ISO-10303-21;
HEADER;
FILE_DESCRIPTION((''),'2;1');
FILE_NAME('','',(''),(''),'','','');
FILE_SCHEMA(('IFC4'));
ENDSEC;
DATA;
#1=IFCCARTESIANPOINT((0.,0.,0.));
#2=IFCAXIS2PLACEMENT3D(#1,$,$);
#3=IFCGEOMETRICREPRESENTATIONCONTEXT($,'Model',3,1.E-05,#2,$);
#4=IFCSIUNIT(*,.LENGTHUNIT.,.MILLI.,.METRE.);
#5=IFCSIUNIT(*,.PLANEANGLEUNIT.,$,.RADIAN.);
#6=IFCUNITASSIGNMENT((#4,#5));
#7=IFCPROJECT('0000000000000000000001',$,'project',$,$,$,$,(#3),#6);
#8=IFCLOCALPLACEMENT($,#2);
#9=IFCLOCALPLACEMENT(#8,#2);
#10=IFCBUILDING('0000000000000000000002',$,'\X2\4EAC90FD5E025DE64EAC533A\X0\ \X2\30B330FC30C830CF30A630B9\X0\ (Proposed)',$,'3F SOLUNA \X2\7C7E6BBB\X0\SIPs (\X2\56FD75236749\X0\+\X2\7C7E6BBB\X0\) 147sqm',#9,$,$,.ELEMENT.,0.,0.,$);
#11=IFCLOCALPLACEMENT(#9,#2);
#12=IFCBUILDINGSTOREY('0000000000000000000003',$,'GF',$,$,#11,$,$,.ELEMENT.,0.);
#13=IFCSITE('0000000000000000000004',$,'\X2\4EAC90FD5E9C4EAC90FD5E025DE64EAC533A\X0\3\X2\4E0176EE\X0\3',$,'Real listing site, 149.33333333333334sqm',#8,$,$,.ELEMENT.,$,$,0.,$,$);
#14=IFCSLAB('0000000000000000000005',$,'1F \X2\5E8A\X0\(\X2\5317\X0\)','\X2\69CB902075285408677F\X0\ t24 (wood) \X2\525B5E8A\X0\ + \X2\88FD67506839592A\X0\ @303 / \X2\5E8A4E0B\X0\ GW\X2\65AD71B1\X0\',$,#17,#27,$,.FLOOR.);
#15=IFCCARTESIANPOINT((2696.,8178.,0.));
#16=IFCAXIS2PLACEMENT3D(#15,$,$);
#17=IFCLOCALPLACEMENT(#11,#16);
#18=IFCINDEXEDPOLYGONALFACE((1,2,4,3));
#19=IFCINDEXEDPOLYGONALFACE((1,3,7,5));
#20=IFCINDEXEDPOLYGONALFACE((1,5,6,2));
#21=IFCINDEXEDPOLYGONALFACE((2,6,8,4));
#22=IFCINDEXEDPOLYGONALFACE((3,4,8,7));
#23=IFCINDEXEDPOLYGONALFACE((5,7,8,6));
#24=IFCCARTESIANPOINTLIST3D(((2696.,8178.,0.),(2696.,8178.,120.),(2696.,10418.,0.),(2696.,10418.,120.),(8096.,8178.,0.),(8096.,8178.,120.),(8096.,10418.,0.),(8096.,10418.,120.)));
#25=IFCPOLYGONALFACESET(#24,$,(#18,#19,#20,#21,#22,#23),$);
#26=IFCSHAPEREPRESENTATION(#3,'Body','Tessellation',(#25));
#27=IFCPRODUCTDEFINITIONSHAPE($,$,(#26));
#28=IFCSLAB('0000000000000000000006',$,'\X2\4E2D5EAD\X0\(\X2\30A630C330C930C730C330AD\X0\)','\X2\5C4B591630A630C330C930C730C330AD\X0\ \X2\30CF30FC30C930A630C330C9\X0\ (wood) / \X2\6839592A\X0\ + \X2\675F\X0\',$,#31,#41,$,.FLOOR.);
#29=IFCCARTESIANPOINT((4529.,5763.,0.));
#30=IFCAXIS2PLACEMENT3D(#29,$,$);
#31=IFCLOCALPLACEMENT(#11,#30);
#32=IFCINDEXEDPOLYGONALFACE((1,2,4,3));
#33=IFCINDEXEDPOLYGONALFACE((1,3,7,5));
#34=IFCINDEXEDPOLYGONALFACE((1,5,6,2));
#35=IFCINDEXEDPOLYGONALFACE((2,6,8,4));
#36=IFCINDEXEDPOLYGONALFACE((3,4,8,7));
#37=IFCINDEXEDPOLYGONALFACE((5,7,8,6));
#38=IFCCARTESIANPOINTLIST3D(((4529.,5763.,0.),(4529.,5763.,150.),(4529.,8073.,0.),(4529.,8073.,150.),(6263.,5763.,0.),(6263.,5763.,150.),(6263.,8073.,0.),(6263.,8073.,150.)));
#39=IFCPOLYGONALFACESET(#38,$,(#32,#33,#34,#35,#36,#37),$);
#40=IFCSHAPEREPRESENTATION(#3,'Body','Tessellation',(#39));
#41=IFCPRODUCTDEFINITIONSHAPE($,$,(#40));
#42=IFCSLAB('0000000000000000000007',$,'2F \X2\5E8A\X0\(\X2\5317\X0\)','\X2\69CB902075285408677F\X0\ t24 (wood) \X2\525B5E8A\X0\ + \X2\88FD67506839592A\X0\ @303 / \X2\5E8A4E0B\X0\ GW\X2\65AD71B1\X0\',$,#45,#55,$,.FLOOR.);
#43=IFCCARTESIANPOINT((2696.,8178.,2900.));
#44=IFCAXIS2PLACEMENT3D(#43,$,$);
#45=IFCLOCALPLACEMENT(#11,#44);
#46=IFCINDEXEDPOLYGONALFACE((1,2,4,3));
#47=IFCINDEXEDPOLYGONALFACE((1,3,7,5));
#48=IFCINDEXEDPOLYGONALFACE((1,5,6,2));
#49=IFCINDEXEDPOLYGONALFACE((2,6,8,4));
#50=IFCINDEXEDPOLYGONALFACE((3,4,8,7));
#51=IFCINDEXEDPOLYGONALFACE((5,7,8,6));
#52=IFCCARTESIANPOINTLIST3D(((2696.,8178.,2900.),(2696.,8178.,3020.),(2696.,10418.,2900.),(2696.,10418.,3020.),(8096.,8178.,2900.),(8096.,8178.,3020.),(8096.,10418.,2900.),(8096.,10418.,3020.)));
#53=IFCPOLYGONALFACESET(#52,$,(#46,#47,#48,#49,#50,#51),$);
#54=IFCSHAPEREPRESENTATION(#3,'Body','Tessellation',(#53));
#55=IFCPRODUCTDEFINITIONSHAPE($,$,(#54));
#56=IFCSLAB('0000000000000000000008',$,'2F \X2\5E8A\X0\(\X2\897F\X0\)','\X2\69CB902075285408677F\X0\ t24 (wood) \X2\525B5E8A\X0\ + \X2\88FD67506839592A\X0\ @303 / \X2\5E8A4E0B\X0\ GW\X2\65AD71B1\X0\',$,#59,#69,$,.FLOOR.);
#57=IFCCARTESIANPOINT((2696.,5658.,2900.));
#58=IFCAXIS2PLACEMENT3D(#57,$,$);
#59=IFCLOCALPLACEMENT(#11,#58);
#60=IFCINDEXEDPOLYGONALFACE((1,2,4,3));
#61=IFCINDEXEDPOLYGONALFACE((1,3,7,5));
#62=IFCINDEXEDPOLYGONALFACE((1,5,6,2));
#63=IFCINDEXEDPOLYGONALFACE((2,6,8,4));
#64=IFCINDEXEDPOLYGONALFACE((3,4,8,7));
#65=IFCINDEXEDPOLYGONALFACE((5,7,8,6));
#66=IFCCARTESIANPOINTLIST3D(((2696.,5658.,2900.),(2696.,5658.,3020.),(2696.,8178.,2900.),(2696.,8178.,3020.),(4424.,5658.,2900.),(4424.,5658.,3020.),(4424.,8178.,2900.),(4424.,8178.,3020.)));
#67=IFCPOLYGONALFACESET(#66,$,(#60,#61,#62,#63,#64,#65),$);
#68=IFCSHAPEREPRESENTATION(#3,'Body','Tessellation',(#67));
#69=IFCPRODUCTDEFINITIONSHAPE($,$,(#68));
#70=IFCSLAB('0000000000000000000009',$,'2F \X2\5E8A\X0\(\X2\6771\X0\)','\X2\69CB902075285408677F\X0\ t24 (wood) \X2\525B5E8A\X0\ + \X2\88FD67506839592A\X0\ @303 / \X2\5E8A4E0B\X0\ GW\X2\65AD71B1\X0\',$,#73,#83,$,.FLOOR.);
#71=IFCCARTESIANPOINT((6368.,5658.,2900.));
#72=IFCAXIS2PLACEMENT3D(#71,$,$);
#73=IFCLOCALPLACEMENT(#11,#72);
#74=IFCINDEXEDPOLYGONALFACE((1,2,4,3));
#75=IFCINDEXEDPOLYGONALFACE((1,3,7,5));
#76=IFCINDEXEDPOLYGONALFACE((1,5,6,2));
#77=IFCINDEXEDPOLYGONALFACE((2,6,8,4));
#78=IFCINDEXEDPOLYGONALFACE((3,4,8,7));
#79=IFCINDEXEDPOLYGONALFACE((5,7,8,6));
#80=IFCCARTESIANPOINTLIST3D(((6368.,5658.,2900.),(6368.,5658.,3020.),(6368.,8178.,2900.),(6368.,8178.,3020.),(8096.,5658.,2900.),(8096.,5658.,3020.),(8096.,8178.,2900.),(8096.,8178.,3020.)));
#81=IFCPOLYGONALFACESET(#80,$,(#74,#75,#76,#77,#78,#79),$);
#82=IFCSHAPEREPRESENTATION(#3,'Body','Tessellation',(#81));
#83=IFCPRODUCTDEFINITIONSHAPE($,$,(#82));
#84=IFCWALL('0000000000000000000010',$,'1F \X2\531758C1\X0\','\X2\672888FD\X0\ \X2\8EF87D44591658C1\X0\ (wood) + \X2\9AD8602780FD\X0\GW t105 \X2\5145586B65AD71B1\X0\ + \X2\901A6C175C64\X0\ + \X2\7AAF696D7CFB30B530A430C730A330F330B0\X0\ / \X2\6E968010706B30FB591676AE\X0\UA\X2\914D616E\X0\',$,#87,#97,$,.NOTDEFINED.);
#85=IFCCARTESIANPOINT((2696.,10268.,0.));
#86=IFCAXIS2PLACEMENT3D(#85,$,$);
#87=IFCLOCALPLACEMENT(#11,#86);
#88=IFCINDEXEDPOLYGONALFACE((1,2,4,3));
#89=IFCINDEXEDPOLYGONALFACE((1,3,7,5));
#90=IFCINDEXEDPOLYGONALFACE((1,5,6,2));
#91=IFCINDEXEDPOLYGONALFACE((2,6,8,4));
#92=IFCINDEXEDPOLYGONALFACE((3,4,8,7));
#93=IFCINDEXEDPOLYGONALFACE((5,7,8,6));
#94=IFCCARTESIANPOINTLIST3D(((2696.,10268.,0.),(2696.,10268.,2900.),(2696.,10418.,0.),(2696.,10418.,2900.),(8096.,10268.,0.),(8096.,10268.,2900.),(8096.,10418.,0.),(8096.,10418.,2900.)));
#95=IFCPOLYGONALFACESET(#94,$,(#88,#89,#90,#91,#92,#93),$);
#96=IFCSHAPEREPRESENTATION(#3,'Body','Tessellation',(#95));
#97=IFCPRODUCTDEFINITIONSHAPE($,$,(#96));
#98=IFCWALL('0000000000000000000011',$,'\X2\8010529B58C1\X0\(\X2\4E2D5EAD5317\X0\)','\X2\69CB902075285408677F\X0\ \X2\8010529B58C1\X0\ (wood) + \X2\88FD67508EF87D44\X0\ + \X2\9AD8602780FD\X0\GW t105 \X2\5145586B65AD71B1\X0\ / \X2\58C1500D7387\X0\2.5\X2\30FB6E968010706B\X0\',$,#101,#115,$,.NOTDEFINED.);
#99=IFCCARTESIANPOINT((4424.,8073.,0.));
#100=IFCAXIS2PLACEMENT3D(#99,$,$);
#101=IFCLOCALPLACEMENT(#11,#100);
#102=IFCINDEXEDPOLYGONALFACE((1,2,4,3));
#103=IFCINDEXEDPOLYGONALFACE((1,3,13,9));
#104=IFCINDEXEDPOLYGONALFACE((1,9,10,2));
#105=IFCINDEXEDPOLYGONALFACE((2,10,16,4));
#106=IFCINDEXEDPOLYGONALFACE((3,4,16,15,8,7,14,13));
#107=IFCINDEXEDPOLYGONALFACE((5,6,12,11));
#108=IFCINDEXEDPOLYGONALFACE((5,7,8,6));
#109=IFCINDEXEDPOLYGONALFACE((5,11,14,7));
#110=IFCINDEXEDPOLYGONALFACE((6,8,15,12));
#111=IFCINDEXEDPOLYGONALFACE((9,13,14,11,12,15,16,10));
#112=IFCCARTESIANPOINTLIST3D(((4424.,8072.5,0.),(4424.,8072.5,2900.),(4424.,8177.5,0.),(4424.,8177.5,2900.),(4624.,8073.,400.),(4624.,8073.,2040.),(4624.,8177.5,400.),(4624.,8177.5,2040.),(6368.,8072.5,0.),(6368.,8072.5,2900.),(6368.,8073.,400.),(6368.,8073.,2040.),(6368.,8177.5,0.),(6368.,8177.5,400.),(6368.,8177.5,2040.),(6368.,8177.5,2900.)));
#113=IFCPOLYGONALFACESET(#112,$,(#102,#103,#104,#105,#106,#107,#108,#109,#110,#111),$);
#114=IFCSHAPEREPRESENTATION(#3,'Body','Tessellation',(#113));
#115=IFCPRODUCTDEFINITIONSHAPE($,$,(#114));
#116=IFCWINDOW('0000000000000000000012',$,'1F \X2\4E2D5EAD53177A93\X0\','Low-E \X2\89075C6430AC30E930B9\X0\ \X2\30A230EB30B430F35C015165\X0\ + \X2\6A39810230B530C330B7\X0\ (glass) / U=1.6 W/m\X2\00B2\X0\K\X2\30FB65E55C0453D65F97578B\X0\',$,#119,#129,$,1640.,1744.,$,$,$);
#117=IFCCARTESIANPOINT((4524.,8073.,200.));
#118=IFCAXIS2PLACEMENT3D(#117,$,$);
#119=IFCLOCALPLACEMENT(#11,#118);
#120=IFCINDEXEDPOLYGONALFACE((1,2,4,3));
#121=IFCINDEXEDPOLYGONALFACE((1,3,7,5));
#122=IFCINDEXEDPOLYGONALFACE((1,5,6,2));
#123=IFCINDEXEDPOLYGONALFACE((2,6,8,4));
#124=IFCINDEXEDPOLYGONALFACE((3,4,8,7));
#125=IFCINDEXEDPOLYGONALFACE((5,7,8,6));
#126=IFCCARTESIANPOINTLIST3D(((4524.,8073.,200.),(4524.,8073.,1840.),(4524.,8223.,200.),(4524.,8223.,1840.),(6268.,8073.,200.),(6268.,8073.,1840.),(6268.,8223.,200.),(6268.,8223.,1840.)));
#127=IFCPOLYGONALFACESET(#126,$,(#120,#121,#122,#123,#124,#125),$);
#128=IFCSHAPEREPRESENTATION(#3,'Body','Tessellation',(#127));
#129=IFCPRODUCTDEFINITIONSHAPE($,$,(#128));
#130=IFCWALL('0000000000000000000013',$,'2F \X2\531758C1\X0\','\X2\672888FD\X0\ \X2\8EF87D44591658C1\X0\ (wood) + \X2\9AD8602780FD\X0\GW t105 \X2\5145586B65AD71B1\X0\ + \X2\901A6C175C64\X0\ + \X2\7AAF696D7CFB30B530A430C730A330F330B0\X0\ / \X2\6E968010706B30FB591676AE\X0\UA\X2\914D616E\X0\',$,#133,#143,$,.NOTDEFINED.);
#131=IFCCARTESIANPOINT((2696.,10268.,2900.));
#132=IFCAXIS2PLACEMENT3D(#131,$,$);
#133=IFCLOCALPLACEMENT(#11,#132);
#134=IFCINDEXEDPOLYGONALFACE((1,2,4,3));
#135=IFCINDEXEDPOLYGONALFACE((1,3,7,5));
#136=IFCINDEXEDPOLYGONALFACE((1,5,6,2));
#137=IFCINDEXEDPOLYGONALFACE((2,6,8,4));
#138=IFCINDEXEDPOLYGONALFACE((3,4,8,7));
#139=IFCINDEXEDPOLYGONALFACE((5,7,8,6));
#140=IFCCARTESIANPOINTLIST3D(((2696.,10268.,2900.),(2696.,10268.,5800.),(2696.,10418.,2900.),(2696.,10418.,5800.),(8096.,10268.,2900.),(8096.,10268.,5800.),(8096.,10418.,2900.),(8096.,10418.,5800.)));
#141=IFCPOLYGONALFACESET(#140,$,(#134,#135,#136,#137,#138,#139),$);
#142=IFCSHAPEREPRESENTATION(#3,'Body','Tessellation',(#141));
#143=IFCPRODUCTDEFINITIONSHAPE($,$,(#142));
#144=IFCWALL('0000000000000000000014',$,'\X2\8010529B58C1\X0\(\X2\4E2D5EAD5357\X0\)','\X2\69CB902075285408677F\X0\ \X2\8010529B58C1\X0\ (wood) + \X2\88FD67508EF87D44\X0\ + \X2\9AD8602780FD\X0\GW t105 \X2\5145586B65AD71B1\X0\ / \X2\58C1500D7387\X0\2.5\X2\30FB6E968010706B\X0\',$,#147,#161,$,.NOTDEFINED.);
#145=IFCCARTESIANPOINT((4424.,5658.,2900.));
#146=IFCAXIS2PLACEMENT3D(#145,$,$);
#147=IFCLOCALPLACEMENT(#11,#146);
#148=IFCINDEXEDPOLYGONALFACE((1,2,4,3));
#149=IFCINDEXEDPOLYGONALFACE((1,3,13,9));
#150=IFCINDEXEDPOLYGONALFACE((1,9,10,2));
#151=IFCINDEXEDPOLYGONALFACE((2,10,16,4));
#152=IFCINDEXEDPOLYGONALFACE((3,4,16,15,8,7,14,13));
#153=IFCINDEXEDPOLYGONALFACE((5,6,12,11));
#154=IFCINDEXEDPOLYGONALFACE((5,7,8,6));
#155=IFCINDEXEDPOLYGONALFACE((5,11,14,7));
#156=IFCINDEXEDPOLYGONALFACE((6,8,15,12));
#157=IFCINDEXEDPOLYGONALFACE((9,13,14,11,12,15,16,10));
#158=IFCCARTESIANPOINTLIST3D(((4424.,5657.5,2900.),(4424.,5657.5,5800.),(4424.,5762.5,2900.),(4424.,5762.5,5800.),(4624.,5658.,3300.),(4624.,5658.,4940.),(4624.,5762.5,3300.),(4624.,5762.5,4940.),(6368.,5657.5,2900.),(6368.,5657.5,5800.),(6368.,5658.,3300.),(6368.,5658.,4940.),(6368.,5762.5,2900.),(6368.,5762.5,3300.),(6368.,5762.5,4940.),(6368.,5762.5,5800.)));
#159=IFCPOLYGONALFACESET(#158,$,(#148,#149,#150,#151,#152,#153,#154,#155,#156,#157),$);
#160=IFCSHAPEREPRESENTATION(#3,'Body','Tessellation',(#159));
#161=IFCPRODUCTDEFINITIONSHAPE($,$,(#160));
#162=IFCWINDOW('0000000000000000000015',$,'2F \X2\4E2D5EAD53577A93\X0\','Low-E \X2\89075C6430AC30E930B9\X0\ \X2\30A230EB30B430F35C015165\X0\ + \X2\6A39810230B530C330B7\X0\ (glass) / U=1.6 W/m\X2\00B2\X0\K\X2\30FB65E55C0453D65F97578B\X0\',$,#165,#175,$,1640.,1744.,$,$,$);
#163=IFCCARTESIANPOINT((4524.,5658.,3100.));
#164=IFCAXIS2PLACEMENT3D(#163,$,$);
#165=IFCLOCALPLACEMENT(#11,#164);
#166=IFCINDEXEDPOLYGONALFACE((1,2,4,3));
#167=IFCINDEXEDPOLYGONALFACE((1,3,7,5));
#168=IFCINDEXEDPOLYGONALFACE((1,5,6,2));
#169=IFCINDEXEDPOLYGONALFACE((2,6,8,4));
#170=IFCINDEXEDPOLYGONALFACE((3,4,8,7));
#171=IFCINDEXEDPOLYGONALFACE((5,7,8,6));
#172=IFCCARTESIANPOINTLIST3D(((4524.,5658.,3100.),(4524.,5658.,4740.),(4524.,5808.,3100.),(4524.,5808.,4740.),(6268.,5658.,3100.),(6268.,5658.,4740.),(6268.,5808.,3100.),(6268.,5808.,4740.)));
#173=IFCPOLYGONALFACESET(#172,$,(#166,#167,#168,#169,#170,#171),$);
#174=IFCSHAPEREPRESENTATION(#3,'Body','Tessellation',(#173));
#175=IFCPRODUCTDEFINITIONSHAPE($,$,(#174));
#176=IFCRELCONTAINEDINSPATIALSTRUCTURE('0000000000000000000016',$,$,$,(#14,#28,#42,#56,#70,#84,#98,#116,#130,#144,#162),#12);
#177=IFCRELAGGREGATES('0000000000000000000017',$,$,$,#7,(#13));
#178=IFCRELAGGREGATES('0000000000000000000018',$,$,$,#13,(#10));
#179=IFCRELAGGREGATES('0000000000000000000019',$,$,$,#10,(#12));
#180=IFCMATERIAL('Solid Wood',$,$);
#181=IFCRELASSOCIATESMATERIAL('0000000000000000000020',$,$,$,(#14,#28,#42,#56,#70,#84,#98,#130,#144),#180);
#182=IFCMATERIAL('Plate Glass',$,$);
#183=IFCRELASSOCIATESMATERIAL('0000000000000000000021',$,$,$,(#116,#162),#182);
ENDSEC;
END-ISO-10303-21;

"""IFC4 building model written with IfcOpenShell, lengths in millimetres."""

from ifc_helpers import new_model, si_unit, frame, frame_2d, origin, place, context, project, spatial, rectangle, extrude, material, element, fill, save


model = new_model("IFC4")

# Units and contexts
model_context = context("Model", 3, precision=1e-05, world=origin())
ifc_project = project(units=[si_unit("LENGTHUNIT", "METRE", prefix="MILLI"), si_unit("PLANEANGLEUNIT", "RADIAN")], contexts=[model_context])

# Site, building, storey
site_placement = place(None, origin())
site = spatial("IfcSite", under=ifc_project, at=site_placement, Name="京都府京都市左京区3丁目3", ObjectType="Real listing site, 149.33333333333334sqm", CompositionType="ELEMENT", RefElevation=0.0)
building_placement = place(site_placement, origin())
building = spatial("IfcBuilding", under=site, at=building_placement, Name="京都市左京区 コートハウス (Proposed)", ObjectType="3F SOLUNA 籾殻SIPs (国産杉+籾殻) 147sqm", CompositionType="ELEMENT", ElevationOfRefHeight=0.0, ElevationOfTerrain=0.0)
storey_placement = place(building_placement, origin())
storey = spatial("IfcBuildingStorey", under=building, at=storey_placement, Name="GF", CompositionType="ELEMENT", Elevation=0.0)

# Slabs
ifc_material_1 = material(Name="Solid Wood")
slab_1_placement = place(storey_placement, frame((2696.0, 8178.0, 0.0)))
element("IfcSlab", 1, at=slab_1_placement, inside=storey, material=ifc_material_1, Name="1F 床(北)", Description="構造用合板 t24 (wood) 剛床 + 製材根太 @303 / 床下 GW断熱", PredefinedType="FLOOR", context=model_context, shape_type="SweptSolid", body=[
    extrude(rectangle(XDim=5400.0, YDim=2240.0, at=frame_2d((2700.0, 1120.0))), frame((2696.0, 8178.0, 0.0)), (0.0, 0.0, 1.0), 120.0),
])
slab_2_placement = place(storey_placement, frame((4529.0, 5763.0, 0.0)))
element("IfcSlab", 2, at=slab_2_placement, inside=storey, material=ifc_material_1, Name="中庭(ウッドデッキ)", Description="屋外ウッドデッキ ハードウッド (wood) / 根太 + 束", PredefinedType="FLOOR", context=model_context, shape_type="SweptSolid", body=[
    extrude(rectangle(XDim=1734.0, YDim=2310.0, at=frame_2d((867.0, 1155.0))), frame((4529.0, 5763.0, 0.0)), (0.0, 0.0, 1.0), 150.0),
])
slab_3_placement = place(storey_placement, frame((2696.0, 8178.0, 2900.0)))
element("IfcSlab", 3, at=slab_3_placement, inside=storey, material=ifc_material_1, Name="2F 床(北)", Description="構造用合板 t24 (wood) 剛床 + 製材根太 @303 / 床下 GW断熱", PredefinedType="FLOOR", context=model_context, shape_type="SweptSolid", body=[
    extrude(rectangle(XDim=5400.0, YDim=2240.0, at=frame_2d((2700.0, 1120.0))), frame((2696.0, 8178.0, 2900.0)), (0.0, 0.0, 1.0), 120.0),
])
slab_4_placement = place(storey_placement, frame((2696.0, 5658.0, 2900.0)))
element("IfcSlab", 4, at=slab_4_placement, inside=storey, material=ifc_material_1, Name="2F 床(西)", Description="構造用合板 t24 (wood) 剛床 + 製材根太 @303 / 床下 GW断熱", PredefinedType="FLOOR", context=model_context, shape_type="SweptSolid", body=[
    extrude(rectangle(XDim=1728.0, YDim=2520.0, at=frame_2d((864.0, 1260.0))), frame((2696.0, 5658.0, 2900.0)), (0.0, 0.0, 1.0), 120.0),
])
slab_5_placement = place(storey_placement, frame((6368.0, 5658.0, 2900.0)))
element("IfcSlab", 5, at=slab_5_placement, inside=storey, material=ifc_material_1, Name="2F 床(東)", Description="構造用合板 t24 (wood) 剛床 + 製材根太 @303 / 床下 GW断熱", PredefinedType="FLOOR", context=model_context, shape_type="SweptSolid", body=[
    extrude(rectangle(XDim=1728.0, YDim=2520.0, at=frame_2d((864.0, 1260.0))), frame((6368.0, 5658.0, 2900.0)), (0.0, 0.0, 1.0), 120.0),
])

# Wall
wall_1_placement = place(storey_placement, frame((2696.0, 10268.0, 0.0)))
element("IfcWall", 6, at=wall_1_placement, inside=storey, material=ifc_material_1, Name="1F 北壁", Description="木製 軸組外壁 (wood) + 高性能GW t105 充填断熱 + 通気層 + 窯業系サイディング / 準耐火・外皮UA配慮", PredefinedType="NOTDEFINED", context=model_context, shape_type="SweptSolid", body=[
    extrude(rectangle(XDim=5400.0, YDim=150.0, at=frame_2d((2700.0, 75.0))), frame((2696.0, 10268.0, 0.0)), (0.0, 0.0, 1.0), 2900.0),
])

# Wall, opening, window
wall_2_placement = place(storey_placement, frame((4424.0, 8073.0, 0.0)))
wall_2 = element("IfcWall", 7, at=wall_2_placement, inside=storey, material=ifc_material_1, Name="耐力壁(中庭北)", Description="構造用合板 耐力壁 (wood) + 製材軸組 + 高性能GW t105 充填断熱 / 壁倍率2.5・準耐火", PredefinedType="NOTDEFINED", context=model_context, shape_type="SweptSolid", body=[
    extrude(rectangle(XDim=1944.0, YDim=105.0, at=frame_2d((972.0, 52.0))), frame((4424.0, 8073.0, 0.0)), (0.0, 0.0, 1.0), 2900.0),
])
opening_1_placement = place(storey_placement, frame((4524.0, 8073.0, 200.0)))
opening_1 = element("IfcOpeningElement", 8, at=opening_1_placement, cuts=wall_2, PredefinedType="NOTDEFINED", context=model_context, shape_type="SweptSolid", body=[
    extrude(rectangle(XDim=1744.0, YDim=150.0, at=frame_2d((872.0, 75.0))), frame((4524.0, 8073.0, 200.0)), (0.0, 0.0, 1.0), 1640.0),
])
ifc_material_2 = material(Name="Plate Glass")
window_1_placement = place(storey_placement, frame((4524.0, 8073.0, 200.0)))
window_1 = element("IfcWindow", 9, at=window_1_placement, inside=storey, material=ifc_material_2, Name="1F 中庭北窓", Description="Low-E 複層ガラス アルゴン封入 + 樹脂サッシ (glass) / U=1.6 W/m²K・日射取得型", OverallHeight=1640.0, OverallWidth=1744.0, context=model_context, shape_type="SweptSolid", body=[
    extrude(rectangle(XDim=1744.0, YDim=150.0, at=frame_2d((872.0, 75.0))), frame((4524.0, 8073.0, 200.0)), (0.0, 0.0, 1.0), 1640.0),
])
fill(opening_1, window_1)

# Wall
wall_3_placement = place(storey_placement, frame((2696.0, 10268.0, 2900.0)))
element("IfcWall", 10, at=wall_3_placement, inside=storey, material=ifc_material_1, Name="2F 北壁", Description="木製 軸組外壁 (wood) + 高性能GW t105 充填断熱 + 通気層 + 窯業系サイディング / 準耐火・外皮UA配慮", PredefinedType="NOTDEFINED", context=model_context, shape_type="SweptSolid", body=[
    extrude(rectangle(XDim=5400.0, YDim=150.0, at=frame_2d((2700.0, 75.0))), frame((2696.0, 10268.0, 2900.0)), (0.0, 0.0, 1.0), 2900.0),
])

# Wall, opening, window
wall_4_placement = place(storey_placement, frame((4424.0, 5658.0, 2900.0)))
wall_4 = element("IfcWall", 11, at=wall_4_placement, inside=storey, material=ifc_material_1, Name="耐力壁(中庭南)", Description="構造用合板 耐力壁 (wood) + 製材軸組 + 高性能GW t105 充填断熱 / 壁倍率2.5・準耐火", PredefinedType="NOTDEFINED", context=model_context, shape_type="SweptSolid", body=[
    extrude(rectangle(XDim=1944.0, YDim=105.0, at=frame_2d((972.0, 52.0))), frame((4424.0, 5658.0, 2900.0)), (0.0, 0.0, 1.0), 2900.0),
])
opening_2_placement = place(storey_placement, frame((4524.0, 5658.0, 3100.0)))
opening_2 = element("IfcOpeningElement", 12, at=opening_2_placement, cuts=wall_4, PredefinedType="NOTDEFINED", context=model_context, shape_type="SweptSolid", body=[
    extrude(rectangle(XDim=1744.0, YDim=150.0, at=frame_2d((872.0, 75.0))), frame((4524.0, 5658.0, 3100.0)), (0.0, 0.0, 1.0), 1640.0),
])
window_2_placement = place(storey_placement, frame((4524.0, 5658.0, 3100.0)))
window_2 = element("IfcWindow", 13, at=window_2_placement, inside=storey, material=ifc_material_2, Name="2F 中庭南窓", Description="Low-E 複層ガラス アルゴン封入 + 樹脂サッシ (glass) / U=1.6 W/m²K・日射取得型", OverallHeight=1640.0, OverallWidth=1744.0, context=model_context, shape_type="SweptSolid", body=[
    extrude(rectangle(XDim=1744.0, YDim=150.0, at=frame_2d((872.0, 75.0))), frame((4524.0, 5658.0, 3100.0)), (0.0, 0.0, 1.0), 1640.0),
])
fill(opening_2, window_2)

save(model, "model.ifc")
